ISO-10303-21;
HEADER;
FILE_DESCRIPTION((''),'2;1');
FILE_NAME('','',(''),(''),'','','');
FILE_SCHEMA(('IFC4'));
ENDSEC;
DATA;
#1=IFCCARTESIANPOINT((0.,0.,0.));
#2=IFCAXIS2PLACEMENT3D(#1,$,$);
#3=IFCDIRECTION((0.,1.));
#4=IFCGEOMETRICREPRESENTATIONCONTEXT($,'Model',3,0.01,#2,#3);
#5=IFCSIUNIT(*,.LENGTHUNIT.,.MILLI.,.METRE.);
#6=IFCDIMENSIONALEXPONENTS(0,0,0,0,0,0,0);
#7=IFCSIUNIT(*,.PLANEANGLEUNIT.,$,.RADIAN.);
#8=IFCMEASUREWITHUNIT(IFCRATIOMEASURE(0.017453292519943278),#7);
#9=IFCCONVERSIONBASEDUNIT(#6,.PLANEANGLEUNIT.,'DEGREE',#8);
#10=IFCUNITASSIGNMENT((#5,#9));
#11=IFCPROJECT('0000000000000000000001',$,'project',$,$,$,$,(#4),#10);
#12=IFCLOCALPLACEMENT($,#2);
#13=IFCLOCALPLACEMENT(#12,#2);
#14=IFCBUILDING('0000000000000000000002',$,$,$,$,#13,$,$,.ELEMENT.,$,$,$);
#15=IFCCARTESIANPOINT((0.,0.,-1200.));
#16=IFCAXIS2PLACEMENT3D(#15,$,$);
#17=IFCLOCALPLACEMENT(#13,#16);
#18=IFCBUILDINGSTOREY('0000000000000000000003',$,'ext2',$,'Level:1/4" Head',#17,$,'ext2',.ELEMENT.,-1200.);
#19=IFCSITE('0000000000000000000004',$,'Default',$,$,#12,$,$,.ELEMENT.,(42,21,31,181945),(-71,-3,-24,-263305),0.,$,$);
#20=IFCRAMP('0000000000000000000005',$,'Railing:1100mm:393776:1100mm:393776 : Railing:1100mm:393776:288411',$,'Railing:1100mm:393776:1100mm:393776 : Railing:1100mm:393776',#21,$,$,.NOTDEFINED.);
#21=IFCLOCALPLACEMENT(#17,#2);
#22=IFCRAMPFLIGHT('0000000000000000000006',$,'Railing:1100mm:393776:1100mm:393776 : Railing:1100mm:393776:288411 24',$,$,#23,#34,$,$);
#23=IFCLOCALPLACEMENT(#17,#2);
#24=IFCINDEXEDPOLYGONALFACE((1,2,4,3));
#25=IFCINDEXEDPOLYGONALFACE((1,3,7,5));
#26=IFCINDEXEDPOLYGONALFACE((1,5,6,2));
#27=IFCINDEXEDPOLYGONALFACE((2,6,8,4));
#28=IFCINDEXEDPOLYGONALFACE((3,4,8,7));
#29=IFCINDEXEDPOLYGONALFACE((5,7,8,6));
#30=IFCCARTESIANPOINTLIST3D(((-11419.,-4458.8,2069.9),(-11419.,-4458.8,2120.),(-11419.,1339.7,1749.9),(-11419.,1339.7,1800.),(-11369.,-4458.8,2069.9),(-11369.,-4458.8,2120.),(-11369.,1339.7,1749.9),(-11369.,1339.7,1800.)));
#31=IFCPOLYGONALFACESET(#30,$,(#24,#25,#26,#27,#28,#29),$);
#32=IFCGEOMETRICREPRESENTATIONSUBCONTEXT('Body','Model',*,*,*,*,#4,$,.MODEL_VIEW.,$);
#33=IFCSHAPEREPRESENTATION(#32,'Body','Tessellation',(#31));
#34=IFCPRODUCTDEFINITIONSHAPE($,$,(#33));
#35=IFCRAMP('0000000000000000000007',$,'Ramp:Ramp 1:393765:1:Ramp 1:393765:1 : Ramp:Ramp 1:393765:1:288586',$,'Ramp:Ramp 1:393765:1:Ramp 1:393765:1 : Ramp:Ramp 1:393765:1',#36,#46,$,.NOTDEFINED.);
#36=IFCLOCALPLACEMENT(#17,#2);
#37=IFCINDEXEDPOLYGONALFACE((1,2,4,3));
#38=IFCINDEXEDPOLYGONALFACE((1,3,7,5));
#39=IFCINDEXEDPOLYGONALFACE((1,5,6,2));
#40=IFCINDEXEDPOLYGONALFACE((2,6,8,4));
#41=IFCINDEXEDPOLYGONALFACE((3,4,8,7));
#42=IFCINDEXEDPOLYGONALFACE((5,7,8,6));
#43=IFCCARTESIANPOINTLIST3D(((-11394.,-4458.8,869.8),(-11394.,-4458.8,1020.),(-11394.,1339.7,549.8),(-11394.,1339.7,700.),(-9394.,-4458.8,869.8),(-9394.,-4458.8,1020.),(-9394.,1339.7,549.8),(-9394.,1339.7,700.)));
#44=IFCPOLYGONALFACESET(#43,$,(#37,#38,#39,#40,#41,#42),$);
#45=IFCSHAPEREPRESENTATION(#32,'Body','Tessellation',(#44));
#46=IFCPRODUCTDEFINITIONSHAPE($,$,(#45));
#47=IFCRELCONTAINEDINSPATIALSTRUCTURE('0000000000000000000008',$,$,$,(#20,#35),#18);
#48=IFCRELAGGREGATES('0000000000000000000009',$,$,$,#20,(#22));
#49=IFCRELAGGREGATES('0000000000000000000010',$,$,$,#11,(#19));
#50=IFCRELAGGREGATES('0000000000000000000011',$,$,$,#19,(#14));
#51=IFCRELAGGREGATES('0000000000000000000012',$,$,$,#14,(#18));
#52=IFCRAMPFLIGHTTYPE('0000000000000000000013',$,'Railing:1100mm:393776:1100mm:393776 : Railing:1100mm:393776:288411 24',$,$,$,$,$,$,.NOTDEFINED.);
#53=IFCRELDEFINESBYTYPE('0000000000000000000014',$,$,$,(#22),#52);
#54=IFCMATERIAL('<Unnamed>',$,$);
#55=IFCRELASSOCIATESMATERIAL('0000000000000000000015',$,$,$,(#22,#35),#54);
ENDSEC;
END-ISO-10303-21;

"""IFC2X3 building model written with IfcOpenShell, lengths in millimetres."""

from ifc_helpers import new_model, entity, si_unit, converted_unit, direction, frame, origin, place, context, subcontext, project, spatial, polyline, outline, extrude, material, type_object, element, aggregate, save


model = new_model("IFC2X3")

# Units and contexts
model_context = context("Model", 3, precision=0.01, world=origin(), true_north=direction((0.0, 1.0)))
body_context = subcontext(model_context, "Body", "Model", "MODEL_VIEW")
ifc_project = project(units=[si_unit("LENGTHUNIT", "METRE", prefix="MILLI"), converted_unit("PLANEANGLEUNIT", "DEGREE", entity("IfcRatioMeasure", 0.017453292519943278), si_unit("PLANEANGLEUNIT", "RADIAN"), dimensions=[0, 0, 0, 0, 0, 0, 0])], contexts=[model_context])

# Site, building, storey
site_placement = place(None, origin())
site = spatial("IfcSite", under=ifc_project, at=site_placement, Name="Default", CompositionType="ELEMENT", RefLatitude=(42, 21, 31, 181945), RefLongitude=(-71, -3, -24, -263305), RefElevation=0.0)
building_placement = place(site_placement, origin())
building = spatial("IfcBuilding", under=site, at=building_placement, CompositionType="ELEMENT")
storey_placement = place(building_placement, frame((0.0, 0.0, -1200.0)))
storey = spatial("IfcBuildingStorey", under=building, at=storey_placement, Name="ext2", ObjectType="Level:1/4\" Head", LongName="ext2", CompositionType="ELEMENT", Elevation=-1200.0)

# Ramp, ramp flight
ramp_1_placement = place(storey_placement, origin())
ramp_1 = element("IfcRamp", 1, at=ramp_1_placement, inside=storey, Name="Railing:1100mm:393776:1100mm:393776 : Railing:1100mm:393776:288411", ObjectType="Railing:1100mm:393776:1100mm:393776 : Railing:1100mm:393776", ShapeType="NOTDEFINED")
ifc_material = material(Name="<Unnamed>")
ramp_flight_type_1 = type_object("IfcRampFlightType", Name="Railing:1100mm:393776:1100mm:393776 : Railing:1100mm:393776:288411 24", PredefinedType="NOTDEFINED")
ramp_flight_1_placement = place(ramp_1_placement, origin())
ramp_flight_1 = element("IfcRampFlight", 2, at=ramp_flight_1_placement, type_object=ramp_flight_type_1, material=ifc_material, Name="Railing:1100mm:393776:1100mm:393776 : Railing:1100mm:393776:288411 24", context=body_context, shape_type="SweptSolid", body=[
    extrude(outline(polyline([(-185.0, -2899.2), (-135.0, -2899.2), (185.0, 2899.2), (135.0, 2899.2), (-185.0, -2899.2)])), frame((-11419.0, -1559.5, 1935.0), z_axis=(1.0, 0.0, 0.0), x_axis=(0.0, 0.0, -1.0)), (0.0, 0.0, 1.0), 50.0),
])
aggregate(ramp_1, [ramp_flight_1])

# Ramp
ramp_2_placement = place(storey_placement, origin())
element("IfcRamp", 3, at=ramp_2_placement, inside=storey, material=ifc_material, Name="Ramp:Ramp 1:393765:1:Ramp 1:393765:1 : Ramp:Ramp 1:393765:1:288586", ObjectType="Ramp:Ramp 1:393765:1:Ramp 1:393765:1 : Ramp:Ramp 1:393765:1", ShapeType="NOTDEFINED", context=body_context, shape_type="SweptSolid", body=[
    extrude(outline(polyline([(-2899.5, -75.0), (2907.8, -75.0), (2899.5, 75.0), (-2907.8, 75.0), (-2899.5, -75.0)])), frame((-11394.0, -1559.5, 784.9), z_axis=(1.0, 0.0, 0.0), x_axis=(0.0, 0.998481, -0.055103)), (0.0, 0.0, 1.0), 2000.0),
])

save(model, "model.ifc")
